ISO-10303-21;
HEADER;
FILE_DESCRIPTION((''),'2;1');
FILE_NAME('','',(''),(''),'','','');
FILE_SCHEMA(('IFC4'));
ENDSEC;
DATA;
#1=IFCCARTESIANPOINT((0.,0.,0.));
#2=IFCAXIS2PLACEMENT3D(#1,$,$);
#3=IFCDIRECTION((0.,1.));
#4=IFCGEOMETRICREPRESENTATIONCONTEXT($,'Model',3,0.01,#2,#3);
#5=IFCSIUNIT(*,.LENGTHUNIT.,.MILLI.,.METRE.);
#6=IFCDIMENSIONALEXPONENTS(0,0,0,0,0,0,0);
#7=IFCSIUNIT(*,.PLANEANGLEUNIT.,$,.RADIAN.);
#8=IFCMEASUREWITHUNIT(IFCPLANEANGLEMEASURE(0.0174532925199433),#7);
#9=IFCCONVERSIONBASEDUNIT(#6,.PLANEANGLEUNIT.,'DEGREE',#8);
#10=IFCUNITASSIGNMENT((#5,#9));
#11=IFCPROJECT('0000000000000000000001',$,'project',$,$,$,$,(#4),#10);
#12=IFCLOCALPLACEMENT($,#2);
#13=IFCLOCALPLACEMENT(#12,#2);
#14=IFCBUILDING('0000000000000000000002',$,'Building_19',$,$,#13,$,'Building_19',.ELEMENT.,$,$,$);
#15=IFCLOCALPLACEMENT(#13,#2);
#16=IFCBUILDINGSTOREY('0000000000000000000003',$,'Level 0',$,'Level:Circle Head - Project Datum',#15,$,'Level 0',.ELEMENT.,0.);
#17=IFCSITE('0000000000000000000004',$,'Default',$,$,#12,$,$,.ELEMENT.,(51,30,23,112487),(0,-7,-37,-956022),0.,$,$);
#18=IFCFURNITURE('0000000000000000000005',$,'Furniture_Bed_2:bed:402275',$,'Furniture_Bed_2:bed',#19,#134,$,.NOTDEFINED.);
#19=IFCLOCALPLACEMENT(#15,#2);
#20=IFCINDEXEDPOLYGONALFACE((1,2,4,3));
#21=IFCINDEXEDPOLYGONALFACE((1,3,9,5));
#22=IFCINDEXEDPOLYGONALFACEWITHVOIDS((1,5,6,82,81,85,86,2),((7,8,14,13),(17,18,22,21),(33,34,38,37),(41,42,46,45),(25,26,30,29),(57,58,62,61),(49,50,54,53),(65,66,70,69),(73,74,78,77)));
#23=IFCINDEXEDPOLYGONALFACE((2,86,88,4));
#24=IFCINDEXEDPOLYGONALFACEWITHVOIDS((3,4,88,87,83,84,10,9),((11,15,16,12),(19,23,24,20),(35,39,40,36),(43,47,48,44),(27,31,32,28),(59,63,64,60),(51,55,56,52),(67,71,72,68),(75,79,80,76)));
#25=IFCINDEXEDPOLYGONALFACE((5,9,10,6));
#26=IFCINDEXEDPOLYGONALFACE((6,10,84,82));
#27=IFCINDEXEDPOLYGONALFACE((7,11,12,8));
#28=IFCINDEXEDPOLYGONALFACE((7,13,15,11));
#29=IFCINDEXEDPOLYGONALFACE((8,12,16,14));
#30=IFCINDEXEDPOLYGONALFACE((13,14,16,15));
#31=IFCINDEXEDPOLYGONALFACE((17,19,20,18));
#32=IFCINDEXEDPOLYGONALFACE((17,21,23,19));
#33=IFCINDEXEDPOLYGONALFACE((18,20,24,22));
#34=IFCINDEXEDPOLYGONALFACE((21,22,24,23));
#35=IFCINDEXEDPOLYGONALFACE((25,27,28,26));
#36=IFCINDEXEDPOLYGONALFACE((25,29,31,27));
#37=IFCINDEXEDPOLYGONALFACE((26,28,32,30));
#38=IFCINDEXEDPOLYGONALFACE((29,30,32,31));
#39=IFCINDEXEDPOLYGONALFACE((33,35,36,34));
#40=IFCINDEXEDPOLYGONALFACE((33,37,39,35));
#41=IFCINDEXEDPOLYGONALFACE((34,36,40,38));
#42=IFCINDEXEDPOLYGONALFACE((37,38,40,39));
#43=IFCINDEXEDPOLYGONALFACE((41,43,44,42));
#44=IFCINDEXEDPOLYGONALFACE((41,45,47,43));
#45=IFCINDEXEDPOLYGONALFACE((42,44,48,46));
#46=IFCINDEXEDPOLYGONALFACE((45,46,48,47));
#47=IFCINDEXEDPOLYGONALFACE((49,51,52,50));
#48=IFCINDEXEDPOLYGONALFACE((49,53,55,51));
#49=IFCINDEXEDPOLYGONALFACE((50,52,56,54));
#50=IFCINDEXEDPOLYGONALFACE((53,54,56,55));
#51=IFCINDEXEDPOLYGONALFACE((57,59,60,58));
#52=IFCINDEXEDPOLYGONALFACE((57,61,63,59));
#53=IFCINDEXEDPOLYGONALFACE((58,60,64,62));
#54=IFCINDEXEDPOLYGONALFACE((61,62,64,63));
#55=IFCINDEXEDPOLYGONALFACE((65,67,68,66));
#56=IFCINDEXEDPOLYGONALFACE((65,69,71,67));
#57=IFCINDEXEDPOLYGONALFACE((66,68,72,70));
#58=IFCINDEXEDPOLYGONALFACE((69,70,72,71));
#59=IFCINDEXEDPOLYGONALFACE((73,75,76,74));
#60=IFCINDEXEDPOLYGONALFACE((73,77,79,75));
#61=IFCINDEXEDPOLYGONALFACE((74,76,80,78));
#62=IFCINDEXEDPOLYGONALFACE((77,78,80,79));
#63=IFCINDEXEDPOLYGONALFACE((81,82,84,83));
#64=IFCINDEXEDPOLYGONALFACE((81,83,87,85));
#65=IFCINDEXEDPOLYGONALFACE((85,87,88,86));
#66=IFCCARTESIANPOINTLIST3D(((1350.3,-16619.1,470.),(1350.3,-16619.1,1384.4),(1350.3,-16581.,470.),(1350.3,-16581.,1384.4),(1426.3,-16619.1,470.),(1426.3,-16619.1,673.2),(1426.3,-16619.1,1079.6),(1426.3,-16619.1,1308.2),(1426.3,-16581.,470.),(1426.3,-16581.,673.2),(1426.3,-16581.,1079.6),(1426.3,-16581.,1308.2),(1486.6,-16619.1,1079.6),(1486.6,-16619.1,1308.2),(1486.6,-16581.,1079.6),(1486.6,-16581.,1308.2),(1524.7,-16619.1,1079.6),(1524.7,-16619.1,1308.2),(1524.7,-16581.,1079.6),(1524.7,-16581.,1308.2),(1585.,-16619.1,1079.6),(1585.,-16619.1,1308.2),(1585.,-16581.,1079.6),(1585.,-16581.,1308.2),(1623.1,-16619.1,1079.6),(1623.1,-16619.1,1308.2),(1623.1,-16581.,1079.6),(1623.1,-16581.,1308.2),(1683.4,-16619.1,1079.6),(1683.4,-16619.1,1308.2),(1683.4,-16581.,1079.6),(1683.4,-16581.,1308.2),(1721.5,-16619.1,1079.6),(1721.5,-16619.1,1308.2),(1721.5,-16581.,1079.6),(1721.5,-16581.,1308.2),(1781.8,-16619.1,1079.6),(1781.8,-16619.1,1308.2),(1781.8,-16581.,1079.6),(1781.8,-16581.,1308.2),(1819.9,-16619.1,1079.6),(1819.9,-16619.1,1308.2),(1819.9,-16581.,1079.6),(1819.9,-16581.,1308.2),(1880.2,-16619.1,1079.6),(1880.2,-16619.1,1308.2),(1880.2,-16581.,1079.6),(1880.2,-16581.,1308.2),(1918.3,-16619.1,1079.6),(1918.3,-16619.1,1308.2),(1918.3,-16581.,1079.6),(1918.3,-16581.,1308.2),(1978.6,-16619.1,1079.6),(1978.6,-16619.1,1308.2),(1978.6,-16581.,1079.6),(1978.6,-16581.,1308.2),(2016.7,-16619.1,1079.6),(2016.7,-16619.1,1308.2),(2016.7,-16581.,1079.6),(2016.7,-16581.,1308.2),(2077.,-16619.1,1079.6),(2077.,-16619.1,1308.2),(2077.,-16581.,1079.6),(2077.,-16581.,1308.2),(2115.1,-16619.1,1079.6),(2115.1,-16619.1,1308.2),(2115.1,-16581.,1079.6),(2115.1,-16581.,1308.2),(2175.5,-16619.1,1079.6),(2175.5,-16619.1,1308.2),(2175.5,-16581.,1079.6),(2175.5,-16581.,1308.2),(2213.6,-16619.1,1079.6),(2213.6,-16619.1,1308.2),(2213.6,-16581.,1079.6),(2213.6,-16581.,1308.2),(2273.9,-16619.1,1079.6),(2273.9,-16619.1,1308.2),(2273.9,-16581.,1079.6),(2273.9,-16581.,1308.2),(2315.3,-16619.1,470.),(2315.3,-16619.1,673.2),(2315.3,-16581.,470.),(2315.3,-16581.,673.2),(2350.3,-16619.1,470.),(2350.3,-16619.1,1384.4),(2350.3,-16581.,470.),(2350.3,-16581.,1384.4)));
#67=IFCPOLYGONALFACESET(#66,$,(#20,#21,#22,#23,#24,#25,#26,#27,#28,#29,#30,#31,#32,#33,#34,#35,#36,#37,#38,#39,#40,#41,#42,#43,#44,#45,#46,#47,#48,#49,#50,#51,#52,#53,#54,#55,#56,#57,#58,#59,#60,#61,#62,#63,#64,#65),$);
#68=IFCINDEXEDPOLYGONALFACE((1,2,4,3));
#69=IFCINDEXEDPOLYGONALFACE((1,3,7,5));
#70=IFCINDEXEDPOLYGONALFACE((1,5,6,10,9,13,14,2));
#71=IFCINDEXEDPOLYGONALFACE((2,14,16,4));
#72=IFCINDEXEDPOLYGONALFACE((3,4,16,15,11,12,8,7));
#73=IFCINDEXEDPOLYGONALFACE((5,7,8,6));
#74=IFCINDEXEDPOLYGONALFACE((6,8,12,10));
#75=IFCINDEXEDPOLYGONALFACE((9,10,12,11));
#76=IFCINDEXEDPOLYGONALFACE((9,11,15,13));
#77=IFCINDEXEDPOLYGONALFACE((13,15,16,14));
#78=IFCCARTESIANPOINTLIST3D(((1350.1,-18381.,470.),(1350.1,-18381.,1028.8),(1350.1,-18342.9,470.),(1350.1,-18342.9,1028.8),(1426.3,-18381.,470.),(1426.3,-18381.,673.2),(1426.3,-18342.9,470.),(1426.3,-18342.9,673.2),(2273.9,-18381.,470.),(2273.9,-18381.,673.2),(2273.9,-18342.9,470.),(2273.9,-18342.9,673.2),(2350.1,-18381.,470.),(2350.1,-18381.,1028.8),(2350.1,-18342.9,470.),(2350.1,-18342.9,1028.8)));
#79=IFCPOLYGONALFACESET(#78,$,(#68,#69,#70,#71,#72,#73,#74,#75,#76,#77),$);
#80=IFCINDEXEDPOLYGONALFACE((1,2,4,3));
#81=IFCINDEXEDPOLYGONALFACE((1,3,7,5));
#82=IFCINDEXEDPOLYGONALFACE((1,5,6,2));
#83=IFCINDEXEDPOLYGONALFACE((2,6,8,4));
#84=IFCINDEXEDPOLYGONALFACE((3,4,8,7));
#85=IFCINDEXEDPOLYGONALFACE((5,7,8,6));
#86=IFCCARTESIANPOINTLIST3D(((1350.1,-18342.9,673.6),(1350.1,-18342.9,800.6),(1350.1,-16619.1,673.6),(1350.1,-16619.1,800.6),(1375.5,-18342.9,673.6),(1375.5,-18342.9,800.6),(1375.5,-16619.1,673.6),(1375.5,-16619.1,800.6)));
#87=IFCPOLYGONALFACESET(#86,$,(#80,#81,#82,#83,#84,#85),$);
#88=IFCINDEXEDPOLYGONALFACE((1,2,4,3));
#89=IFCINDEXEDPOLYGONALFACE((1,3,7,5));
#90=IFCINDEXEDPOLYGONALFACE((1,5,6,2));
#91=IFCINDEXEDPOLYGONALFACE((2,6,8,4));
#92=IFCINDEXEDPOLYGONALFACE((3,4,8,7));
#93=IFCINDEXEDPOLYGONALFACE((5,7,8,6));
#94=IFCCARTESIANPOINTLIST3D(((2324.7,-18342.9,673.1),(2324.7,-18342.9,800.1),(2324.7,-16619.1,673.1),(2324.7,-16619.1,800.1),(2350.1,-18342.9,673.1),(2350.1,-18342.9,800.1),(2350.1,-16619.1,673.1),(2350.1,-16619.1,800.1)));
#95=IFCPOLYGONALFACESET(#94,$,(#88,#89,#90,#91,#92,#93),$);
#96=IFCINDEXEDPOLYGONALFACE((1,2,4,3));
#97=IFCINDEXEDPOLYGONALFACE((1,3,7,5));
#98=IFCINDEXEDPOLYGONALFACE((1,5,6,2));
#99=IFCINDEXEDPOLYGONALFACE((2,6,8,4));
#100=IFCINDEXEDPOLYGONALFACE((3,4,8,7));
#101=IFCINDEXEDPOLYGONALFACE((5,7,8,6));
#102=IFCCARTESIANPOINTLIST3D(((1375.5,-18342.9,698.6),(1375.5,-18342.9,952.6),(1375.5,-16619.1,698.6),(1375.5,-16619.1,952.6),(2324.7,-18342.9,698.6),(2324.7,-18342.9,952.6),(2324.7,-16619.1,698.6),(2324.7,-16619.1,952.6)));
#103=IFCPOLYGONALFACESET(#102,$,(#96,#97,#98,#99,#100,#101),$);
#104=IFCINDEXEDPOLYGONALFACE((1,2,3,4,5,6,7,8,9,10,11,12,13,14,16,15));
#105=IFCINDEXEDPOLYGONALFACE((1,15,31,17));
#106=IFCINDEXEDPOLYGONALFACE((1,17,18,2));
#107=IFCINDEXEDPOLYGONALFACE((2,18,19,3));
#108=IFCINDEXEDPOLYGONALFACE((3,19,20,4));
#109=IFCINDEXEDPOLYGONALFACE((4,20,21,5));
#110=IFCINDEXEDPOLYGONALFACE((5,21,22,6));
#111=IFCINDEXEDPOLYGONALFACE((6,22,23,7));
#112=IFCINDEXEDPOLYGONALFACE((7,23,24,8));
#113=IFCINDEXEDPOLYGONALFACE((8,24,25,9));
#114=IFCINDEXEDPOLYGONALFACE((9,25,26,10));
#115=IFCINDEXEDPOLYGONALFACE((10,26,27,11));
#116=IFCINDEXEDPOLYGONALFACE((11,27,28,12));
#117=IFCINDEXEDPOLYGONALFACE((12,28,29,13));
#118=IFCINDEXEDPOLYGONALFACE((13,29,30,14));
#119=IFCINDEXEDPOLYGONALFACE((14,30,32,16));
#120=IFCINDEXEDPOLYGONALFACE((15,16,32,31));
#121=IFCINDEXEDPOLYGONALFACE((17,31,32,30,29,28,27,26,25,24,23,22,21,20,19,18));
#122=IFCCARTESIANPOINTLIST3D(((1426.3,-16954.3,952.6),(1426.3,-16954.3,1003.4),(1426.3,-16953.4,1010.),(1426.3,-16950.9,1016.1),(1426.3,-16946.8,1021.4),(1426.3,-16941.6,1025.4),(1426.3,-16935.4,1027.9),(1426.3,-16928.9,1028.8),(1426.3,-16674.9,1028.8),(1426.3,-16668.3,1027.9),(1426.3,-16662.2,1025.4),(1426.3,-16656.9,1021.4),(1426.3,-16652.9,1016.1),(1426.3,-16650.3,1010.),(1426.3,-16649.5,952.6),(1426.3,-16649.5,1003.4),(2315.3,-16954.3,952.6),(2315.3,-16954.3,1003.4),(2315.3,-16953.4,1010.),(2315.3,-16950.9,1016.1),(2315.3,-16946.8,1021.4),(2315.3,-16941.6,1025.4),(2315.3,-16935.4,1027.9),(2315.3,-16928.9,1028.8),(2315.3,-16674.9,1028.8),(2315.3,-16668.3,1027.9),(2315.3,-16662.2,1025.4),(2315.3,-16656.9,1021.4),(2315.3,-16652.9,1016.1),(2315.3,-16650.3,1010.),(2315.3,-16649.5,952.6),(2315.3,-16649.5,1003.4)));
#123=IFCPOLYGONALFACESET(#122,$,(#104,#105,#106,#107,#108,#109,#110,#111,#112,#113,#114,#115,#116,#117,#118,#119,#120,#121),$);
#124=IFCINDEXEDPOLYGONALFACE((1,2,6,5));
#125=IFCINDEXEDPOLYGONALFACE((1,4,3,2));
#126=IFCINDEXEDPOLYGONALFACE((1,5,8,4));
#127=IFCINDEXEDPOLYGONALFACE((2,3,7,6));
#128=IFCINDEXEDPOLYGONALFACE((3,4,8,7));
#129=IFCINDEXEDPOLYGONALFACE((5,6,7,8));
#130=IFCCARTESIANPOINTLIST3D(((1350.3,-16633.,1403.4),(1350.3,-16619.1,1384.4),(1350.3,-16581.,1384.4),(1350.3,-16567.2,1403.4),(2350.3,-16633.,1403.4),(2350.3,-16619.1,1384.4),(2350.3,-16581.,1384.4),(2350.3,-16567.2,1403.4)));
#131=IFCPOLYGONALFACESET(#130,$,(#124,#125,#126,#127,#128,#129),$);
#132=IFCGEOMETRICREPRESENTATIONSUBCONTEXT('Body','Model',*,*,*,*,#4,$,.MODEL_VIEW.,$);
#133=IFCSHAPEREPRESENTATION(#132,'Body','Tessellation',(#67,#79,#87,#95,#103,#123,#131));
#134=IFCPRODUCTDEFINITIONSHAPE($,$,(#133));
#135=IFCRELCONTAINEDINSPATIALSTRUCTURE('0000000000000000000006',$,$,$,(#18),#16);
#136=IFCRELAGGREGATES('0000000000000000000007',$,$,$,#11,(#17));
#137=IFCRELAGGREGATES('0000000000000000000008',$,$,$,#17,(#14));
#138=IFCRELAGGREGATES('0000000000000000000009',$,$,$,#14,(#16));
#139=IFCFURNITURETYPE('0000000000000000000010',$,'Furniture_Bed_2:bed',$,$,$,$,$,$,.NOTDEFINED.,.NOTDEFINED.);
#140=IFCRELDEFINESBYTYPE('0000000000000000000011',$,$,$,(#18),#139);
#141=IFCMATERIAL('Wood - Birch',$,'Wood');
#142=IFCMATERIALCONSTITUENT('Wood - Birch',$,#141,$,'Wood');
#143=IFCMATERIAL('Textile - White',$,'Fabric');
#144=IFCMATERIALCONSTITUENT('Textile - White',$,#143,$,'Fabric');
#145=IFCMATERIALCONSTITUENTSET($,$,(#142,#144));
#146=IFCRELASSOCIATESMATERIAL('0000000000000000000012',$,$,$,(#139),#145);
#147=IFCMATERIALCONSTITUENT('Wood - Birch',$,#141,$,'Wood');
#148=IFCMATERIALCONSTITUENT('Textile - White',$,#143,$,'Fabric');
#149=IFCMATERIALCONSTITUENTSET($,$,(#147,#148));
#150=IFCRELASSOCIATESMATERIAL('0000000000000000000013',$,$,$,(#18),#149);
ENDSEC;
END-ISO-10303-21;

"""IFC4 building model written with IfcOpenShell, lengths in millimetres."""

from ifc_helpers import new_model, entity, si_unit, converted_unit, direction, frame, origin, place, context, subcontext, project, spatial, line, arc, indexed_curve, outline, extrude, source, transform, mapped, material, constituent, constituent_set, type_object, type_shapes, element, save


model = new_model("IFC4")

# Units and contexts
model_context = context("Model", 3, precision=0.01, world=origin(), true_north=direction((0.0, 1.0)))
body_context = subcontext(model_context, "Body", "Model", "MODEL_VIEW")
ifc_project = project(units=[si_unit("LENGTHUNIT", "METRE", prefix="MILLI"), converted_unit("PLANEANGLEUNIT", "DEGREE", entity("IfcPlaneAngleMeasure", 0.0174532925199433), si_unit("PLANEANGLEUNIT", "RADIAN"), dimensions=[0, 0, 0, 0, 0, 0, 0])], contexts=[model_context])

# Site, building, storey
site_placement = place(None, origin())
site = spatial("IfcSite", under=ifc_project, at=site_placement, Name="Default", CompositionType="ELEMENT", RefLatitude=(51, 30, 23, 112487), RefLongitude=(0, -7, -37, -956022), RefElevation=0.0)
building_placement = place(site_placement, origin())
building = spatial("IfcBuilding", under=site, at=building_placement, Name="Building_19", LongName="Building_19", CompositionType="ELEMENT")
storey_placement = place(building_placement, origin())
storey = spatial("IfcBuildingStorey", under=building, at=storey_placement, Name="Level 0", ObjectType="Level:Circle Head - Project Datum", LongName="Level 0", CompositionType="ELEMENT", Elevation=0.0)

# Furniture
ifc_material_1 = material(Name="Wood - Birch", Category="Wood")
ifc_constituent_1 = constituent(ifc_material_1, Name="Wood - Birch", Category="Wood")
ifc_material_2 = material(Name="Textile - White", Category="Fabric")
ifc_constituent_2 = constituent(ifc_material_2, Name="Textile - White", Category="Fabric")
ifc_constituent_set_1 = constituent_set(constituents=[ifc_constituent_1, ifc_constituent_2])
ifc_constituent_3 = constituent(ifc_material_1, Name="Wood - Birch", Category="Wood")
ifc_constituent_4 = constituent(ifc_material_2, Name="Textile - White", Category="Fabric")
ifc_constituent_set_2 = constituent_set(constituents=[ifc_constituent_3, ifc_constituent_4])
furniture_type = type_object("IfcFurnitureType", Name="Furniture_Bed_2:bed", AssemblyPlace="NOTDEFINED", PredefinedType="NOTDEFINED", material=ifc_constituent_set_2)
shared_shape_1 = source(origin(), body_context, "Body", "SweptSolid", [
    extrude(outline(indexed_curve([(-635.0, -489.8), (279.4, -489.8), (279.4, -454.7), (76.2, -454.7), (76.2, 434.3), (279.4, 434.3), (279.4, 510.3), (-635.0, 510.3), (-635.0, -489.8)], self_intersect=False), holes=[indexed_curve([(-558.8, 374.0), (-558.8, 434.3), (-330.2, 434.3), (-330.2, 374.0), (-558.8, 374.0)], self_intersect=False), indexed_curve([(-558.8, 275.5), (-558.8, 335.9), (-330.2, 335.9), (-330.2, 275.5), (-558.8, 275.5)], self_intersect=False), indexed_curve([(-558.8, 177.1), (-558.8, 237.4), (-330.2, 237.4), (-330.2, 177.1), (-558.8, 177.1)], self_intersect=False), indexed_curve([(-558.8, 78.7), (-558.8, 139.0), (-330.2, 139.0), (-330.2, 78.7), (-558.8, 78.7)], self_intersect=False), indexed_curve([(-558.8, -118.1), (-558.8, -57.8), (-330.2, -57.8), (-330.2, -118.1), (-558.8, -118.1)], self_intersect=False), indexed_curve([(-558.8, -216.5), (-558.8, -156.2), (-330.2, -156.2), (-330.2, -216.5), (-558.8, -216.5)], self_intersect=False), indexed_curve([(-558.8, -314.9), (-558.8, -254.6), (-330.2, -254.6), (-330.2, -314.9), (-558.8, -314.9)], self_intersect=False), indexed_curve([(-558.8, -413.3), (-558.8, -353.0), (-330.2, -353.0), (-330.2, -413.3), (-558.8, -413.3)], self_intersect=False), indexed_curve([(-558.8, -19.7), (-558.8, 40.6), (-330.2, 40.6), (-330.2, -19.7), (-558.8, -19.7)], self_intersect=False)]), frame((-8.6, -38.1, 279.4), z_axis=(0.0, 1.0, 0.0), x_axis=(0.0, 0.0, -1.0)), (0.0, 0.0, 1.0), 38.1),
    extrude(outline(indexed_curve([(423.8, -190.5), (500.0, -190.5), (500.0, 368.3), (-500.0, 368.3), (-500.0, -190.5), (-423.8, -190.5), (-423.8, 12.7), (423.8, 12.7), (423.8, -190.5)], self_intersect=False)), frame((-19.1, -1800.0, 190.5), z_axis=(0.0, 1.0, 0.0), x_axis=(-1.0, 0.0, 0.0)), (0.0, 0.0, 1.0), 38.1),
    extrude(outline(indexed_curve([(-12.7, -861.9), (12.7, -861.9), (12.7, 861.9), (-12.7, 861.9), (-12.7, -861.9)], self_intersect=False)), frame((-506.4, -900.0, 203.6)), (0.0, 0.0, 1.0), 127.0),
    extrude(outline(indexed_curve([(-12.7, -861.9), (12.7, -861.9), (12.7, 861.9), (-12.7, 861.9), (-12.7, -861.9)], self_intersect=False)), frame((468.2, -900.0, 203.1)), (0.0, 0.0, 1.0), 127.0),
    extrude(outline(indexed_curve([(-474.6, -861.9), (474.6, -861.9), (474.6, 861.9), (-474.6, 861.9), (-474.6, -861.9)], self_intersect=False)), frame((-19.0, -900.0, 228.6), z_axis=(0.0, 0.0, 1.0), x_axis=(-1.0, 0.0, 0.0)), (0.0, 0.0, 1.0), 254.0),
    extrude(outline(indexed_curve([(-152.4, -42.3), (152.4, -42.3), (152.4, 8.5), (145.0, 26.4), (127.0, 33.9), (-127.0, 33.9), (-145.0, 26.4), (-152.4, 8.5)], segments=[line(1, 2, 3), arc(3, 4, 5), line(5, 6), arc(6, 7, 8), line(8, 1)], self_intersect=False)), frame((-442.9, -220.8, 524.9), z_axis=(1.0, 0.0, 0.0), x_axis=(0.0, 1.0, 0.0)), (0.0, 0.0, 1.0), 889.0),
    extrude(outline(indexed_curve([(-19.1, -9.5), (19.0, -9.5), (32.9, 9.5), (-32.9, 9.5), (-19.1, -9.5)], self_intersect=False)), frame((-518.8, -19.0, 923.9), z_axis=(1.0, 0.0, 0.0), x_axis=(0.0, 1.0, 0.0)), (0.0, 0.0, 1.0), 1000.1),
])
type_shapes(furniture_type, [shared_shape_1])
furniture_placement = place(storey_placement, frame((1869.1, -16581.0, 470.0)))
element("IfcFurniture", 1, at=furniture_placement, inside=storey, type_object=furniture_type, material=ifc_constituent_set_1, Name="Furniture_Bed_2:bed:402275", ObjectType="Furniture_Bed_2:bed", PredefinedType="NOTDEFINED", context=body_context, shape_type="MappedRepresentation", body=[
    mapped(shared_shape_1, transform((0.0, 0.0, 0.0), scale=1.0)),
])

save(model, "model.ifc")
